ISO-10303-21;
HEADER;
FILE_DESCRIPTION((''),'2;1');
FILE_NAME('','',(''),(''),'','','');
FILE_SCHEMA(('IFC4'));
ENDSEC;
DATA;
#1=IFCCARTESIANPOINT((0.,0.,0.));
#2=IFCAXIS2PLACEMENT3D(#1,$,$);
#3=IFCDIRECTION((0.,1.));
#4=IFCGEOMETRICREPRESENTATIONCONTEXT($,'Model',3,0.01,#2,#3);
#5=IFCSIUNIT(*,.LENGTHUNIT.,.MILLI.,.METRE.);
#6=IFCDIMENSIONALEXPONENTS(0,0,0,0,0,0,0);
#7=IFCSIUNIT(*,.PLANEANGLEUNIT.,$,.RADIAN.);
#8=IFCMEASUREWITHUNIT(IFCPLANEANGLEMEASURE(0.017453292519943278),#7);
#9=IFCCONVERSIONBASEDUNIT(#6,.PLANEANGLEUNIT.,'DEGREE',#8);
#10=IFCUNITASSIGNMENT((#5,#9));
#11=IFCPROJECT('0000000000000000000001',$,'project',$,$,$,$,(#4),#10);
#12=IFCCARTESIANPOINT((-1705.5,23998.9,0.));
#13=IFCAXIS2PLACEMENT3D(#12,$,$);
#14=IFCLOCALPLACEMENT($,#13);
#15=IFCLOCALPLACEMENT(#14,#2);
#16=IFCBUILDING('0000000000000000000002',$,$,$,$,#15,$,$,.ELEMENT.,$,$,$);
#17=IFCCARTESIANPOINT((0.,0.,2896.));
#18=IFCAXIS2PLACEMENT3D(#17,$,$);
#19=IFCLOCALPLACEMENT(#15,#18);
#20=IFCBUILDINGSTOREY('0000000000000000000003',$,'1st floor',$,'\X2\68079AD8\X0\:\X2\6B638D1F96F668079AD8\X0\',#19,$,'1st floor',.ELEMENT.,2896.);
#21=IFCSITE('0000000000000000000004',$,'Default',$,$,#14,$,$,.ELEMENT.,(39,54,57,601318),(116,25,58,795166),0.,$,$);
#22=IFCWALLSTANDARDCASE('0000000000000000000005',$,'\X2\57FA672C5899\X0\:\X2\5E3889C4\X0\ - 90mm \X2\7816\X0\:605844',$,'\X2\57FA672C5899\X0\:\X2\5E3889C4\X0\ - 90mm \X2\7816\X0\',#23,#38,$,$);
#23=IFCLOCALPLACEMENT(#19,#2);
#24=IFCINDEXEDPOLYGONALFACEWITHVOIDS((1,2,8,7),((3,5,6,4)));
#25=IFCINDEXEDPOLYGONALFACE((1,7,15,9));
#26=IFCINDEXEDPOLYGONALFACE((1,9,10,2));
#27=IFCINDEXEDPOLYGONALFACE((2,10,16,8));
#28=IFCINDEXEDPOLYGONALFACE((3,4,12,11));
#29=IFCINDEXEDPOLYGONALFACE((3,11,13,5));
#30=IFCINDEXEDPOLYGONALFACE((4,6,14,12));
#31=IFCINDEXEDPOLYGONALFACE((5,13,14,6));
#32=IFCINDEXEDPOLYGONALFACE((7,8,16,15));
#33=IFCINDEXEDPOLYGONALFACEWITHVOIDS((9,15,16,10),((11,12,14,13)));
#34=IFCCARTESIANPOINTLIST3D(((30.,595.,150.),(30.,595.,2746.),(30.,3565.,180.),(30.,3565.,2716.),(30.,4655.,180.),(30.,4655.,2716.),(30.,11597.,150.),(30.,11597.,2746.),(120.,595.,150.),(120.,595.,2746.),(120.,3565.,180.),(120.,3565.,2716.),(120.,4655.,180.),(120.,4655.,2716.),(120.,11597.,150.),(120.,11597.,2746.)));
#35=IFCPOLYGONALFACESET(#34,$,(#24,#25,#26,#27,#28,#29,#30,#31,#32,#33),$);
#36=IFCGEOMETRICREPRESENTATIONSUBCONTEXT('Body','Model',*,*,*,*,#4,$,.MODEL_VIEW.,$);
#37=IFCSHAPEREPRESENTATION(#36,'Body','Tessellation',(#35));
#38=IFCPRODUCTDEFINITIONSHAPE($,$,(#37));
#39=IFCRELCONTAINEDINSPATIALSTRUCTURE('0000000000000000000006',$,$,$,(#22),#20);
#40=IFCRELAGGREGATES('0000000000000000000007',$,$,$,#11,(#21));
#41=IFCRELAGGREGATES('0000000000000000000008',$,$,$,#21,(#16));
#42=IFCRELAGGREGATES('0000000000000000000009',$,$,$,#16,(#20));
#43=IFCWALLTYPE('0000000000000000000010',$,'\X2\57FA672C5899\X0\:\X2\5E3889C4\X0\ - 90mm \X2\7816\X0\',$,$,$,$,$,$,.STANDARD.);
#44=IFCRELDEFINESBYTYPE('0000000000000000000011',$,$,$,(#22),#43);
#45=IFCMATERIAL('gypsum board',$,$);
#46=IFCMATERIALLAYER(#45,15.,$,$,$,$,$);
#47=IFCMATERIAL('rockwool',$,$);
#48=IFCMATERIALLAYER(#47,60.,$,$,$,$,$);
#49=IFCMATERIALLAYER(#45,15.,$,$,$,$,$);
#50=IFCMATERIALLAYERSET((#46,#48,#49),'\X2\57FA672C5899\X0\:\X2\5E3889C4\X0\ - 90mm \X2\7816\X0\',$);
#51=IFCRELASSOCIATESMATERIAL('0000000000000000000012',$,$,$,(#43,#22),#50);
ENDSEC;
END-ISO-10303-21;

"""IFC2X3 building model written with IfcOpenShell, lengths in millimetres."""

from ifc_helpers import new_model, entity, si_unit, converted_unit, direction, frame, frame_2d, origin, place, context, subcontext, project, spatial, rectangle, extrude, material, layer, layer_set, layer_usage, type_object, element, save


model = new_model("IFC2X3")

# Units and contexts
model_context = context("Model", 3, precision=0.01, world=origin(), true_north=direction((0.0, 1.0)))
body_context = subcontext(model_context, "Body", "Model", "MODEL_VIEW")
ifc_project = project(units=[si_unit("LENGTHUNIT", "METRE", prefix="MILLI"), converted_unit("PLANEANGLEUNIT", "DEGREE", entity("IfcPlaneAngleMeasure", 0.017453292519943278), si_unit("PLANEANGLEUNIT", "RADIAN"), dimensions=[0, 0, 0, 0, 0, 0, 0])], contexts=[model_context])

# Site, building, storey
site_placement = place(None, frame((-1705.5, 23998.9, 0.0)))
site = spatial("IfcSite", under=ifc_project, at=site_placement, Name="Default", CompositionType="ELEMENT", RefLatitude=(39, 54, 57, 601318), RefLongitude=(116, 25, 58, 795166), RefElevation=0.0)
building_placement = place(site_placement, origin())
building = spatial("IfcBuilding", under=site, at=building_placement, CompositionType="ELEMENT")
storey_placement = place(building_placement, frame((0.0, 0.0, 2896.0)))
storey = spatial("IfcBuildingStorey", under=building, at=storey_placement, Name="1st floor", ObjectType="标高:正负零标高", LongName="1st floor", CompositionType="ELEMENT", Elevation=2896.0)

# Shared definitions
ifc_material_1 = material(Name="gypsum board")
ifc_layer_1 = layer(ifc_material_1, 15.0)
ifc_material_2 = material(Name="rockwool")
ifc_layer_2 = layer(ifc_material_2, 60.0)
ifc_layer_3 = layer(ifc_material_1, 15.0)
ifc_layer_set = layer_set([ifc_layer_1, ifc_layer_2, ifc_layer_3], Name="基本墙:常规 - 90mm 砖")
wall_type = type_object("IfcWallType", Name="基本墙:常规 - 90mm 砖", PredefinedType="STANDARD", material=ifc_layer_set)

# Wall, opening
ifc_layer_usage_1 = layer_usage(ifc_layer_set, "AXIS2", "NEGATIVE", 45.0)
wall_1_placement = place(storey_placement, frame((75.0, 11597.0, 150.0), z_axis=(0.0, 0.0, 1.0), x_axis=(0.0, -1.0, 0.0)))
wall_1 = element("IfcWallStandardCase", 1, at=wall_1_placement, inside=storey, type_object=wall_type, material=ifc_layer_usage_1, Name="基本墙:常规 - 90mm 砖:605844", ObjectType="基本墙:常规 - 90mm 砖", context=body_context, shape_type="SweptSolid", body=[
    extrude(rectangle(XDim=11002.0, YDim=90.0, at=frame_2d((5501.0, 0.0), x_axis=(-1.0, 0.0))), origin(), (0.0, 0.0, 1.0), 2596.0),
])
opening_1_placement = place(wall_1_placement, origin())
element("IfcOpeningElement", 2, at=opening_1_placement, cuts=wall_1, ObjectType="Opening", context=body_context, shape_type="SweptSolid", body=[
    extrude(rectangle(XDim=2536.0, YDim=1090.0, at=frame_2d((0.0, 0.0), x_axis=(0.0, 1.0))), frame((7487.0, 45.0, 1298.0), z_axis=(0.0, -1.0, 0.0), x_axis=(-1.0, 0.0, 0.0)), (0.0, 0.0, 1.0), 90.0),
])

save(model, "model.ifc")
